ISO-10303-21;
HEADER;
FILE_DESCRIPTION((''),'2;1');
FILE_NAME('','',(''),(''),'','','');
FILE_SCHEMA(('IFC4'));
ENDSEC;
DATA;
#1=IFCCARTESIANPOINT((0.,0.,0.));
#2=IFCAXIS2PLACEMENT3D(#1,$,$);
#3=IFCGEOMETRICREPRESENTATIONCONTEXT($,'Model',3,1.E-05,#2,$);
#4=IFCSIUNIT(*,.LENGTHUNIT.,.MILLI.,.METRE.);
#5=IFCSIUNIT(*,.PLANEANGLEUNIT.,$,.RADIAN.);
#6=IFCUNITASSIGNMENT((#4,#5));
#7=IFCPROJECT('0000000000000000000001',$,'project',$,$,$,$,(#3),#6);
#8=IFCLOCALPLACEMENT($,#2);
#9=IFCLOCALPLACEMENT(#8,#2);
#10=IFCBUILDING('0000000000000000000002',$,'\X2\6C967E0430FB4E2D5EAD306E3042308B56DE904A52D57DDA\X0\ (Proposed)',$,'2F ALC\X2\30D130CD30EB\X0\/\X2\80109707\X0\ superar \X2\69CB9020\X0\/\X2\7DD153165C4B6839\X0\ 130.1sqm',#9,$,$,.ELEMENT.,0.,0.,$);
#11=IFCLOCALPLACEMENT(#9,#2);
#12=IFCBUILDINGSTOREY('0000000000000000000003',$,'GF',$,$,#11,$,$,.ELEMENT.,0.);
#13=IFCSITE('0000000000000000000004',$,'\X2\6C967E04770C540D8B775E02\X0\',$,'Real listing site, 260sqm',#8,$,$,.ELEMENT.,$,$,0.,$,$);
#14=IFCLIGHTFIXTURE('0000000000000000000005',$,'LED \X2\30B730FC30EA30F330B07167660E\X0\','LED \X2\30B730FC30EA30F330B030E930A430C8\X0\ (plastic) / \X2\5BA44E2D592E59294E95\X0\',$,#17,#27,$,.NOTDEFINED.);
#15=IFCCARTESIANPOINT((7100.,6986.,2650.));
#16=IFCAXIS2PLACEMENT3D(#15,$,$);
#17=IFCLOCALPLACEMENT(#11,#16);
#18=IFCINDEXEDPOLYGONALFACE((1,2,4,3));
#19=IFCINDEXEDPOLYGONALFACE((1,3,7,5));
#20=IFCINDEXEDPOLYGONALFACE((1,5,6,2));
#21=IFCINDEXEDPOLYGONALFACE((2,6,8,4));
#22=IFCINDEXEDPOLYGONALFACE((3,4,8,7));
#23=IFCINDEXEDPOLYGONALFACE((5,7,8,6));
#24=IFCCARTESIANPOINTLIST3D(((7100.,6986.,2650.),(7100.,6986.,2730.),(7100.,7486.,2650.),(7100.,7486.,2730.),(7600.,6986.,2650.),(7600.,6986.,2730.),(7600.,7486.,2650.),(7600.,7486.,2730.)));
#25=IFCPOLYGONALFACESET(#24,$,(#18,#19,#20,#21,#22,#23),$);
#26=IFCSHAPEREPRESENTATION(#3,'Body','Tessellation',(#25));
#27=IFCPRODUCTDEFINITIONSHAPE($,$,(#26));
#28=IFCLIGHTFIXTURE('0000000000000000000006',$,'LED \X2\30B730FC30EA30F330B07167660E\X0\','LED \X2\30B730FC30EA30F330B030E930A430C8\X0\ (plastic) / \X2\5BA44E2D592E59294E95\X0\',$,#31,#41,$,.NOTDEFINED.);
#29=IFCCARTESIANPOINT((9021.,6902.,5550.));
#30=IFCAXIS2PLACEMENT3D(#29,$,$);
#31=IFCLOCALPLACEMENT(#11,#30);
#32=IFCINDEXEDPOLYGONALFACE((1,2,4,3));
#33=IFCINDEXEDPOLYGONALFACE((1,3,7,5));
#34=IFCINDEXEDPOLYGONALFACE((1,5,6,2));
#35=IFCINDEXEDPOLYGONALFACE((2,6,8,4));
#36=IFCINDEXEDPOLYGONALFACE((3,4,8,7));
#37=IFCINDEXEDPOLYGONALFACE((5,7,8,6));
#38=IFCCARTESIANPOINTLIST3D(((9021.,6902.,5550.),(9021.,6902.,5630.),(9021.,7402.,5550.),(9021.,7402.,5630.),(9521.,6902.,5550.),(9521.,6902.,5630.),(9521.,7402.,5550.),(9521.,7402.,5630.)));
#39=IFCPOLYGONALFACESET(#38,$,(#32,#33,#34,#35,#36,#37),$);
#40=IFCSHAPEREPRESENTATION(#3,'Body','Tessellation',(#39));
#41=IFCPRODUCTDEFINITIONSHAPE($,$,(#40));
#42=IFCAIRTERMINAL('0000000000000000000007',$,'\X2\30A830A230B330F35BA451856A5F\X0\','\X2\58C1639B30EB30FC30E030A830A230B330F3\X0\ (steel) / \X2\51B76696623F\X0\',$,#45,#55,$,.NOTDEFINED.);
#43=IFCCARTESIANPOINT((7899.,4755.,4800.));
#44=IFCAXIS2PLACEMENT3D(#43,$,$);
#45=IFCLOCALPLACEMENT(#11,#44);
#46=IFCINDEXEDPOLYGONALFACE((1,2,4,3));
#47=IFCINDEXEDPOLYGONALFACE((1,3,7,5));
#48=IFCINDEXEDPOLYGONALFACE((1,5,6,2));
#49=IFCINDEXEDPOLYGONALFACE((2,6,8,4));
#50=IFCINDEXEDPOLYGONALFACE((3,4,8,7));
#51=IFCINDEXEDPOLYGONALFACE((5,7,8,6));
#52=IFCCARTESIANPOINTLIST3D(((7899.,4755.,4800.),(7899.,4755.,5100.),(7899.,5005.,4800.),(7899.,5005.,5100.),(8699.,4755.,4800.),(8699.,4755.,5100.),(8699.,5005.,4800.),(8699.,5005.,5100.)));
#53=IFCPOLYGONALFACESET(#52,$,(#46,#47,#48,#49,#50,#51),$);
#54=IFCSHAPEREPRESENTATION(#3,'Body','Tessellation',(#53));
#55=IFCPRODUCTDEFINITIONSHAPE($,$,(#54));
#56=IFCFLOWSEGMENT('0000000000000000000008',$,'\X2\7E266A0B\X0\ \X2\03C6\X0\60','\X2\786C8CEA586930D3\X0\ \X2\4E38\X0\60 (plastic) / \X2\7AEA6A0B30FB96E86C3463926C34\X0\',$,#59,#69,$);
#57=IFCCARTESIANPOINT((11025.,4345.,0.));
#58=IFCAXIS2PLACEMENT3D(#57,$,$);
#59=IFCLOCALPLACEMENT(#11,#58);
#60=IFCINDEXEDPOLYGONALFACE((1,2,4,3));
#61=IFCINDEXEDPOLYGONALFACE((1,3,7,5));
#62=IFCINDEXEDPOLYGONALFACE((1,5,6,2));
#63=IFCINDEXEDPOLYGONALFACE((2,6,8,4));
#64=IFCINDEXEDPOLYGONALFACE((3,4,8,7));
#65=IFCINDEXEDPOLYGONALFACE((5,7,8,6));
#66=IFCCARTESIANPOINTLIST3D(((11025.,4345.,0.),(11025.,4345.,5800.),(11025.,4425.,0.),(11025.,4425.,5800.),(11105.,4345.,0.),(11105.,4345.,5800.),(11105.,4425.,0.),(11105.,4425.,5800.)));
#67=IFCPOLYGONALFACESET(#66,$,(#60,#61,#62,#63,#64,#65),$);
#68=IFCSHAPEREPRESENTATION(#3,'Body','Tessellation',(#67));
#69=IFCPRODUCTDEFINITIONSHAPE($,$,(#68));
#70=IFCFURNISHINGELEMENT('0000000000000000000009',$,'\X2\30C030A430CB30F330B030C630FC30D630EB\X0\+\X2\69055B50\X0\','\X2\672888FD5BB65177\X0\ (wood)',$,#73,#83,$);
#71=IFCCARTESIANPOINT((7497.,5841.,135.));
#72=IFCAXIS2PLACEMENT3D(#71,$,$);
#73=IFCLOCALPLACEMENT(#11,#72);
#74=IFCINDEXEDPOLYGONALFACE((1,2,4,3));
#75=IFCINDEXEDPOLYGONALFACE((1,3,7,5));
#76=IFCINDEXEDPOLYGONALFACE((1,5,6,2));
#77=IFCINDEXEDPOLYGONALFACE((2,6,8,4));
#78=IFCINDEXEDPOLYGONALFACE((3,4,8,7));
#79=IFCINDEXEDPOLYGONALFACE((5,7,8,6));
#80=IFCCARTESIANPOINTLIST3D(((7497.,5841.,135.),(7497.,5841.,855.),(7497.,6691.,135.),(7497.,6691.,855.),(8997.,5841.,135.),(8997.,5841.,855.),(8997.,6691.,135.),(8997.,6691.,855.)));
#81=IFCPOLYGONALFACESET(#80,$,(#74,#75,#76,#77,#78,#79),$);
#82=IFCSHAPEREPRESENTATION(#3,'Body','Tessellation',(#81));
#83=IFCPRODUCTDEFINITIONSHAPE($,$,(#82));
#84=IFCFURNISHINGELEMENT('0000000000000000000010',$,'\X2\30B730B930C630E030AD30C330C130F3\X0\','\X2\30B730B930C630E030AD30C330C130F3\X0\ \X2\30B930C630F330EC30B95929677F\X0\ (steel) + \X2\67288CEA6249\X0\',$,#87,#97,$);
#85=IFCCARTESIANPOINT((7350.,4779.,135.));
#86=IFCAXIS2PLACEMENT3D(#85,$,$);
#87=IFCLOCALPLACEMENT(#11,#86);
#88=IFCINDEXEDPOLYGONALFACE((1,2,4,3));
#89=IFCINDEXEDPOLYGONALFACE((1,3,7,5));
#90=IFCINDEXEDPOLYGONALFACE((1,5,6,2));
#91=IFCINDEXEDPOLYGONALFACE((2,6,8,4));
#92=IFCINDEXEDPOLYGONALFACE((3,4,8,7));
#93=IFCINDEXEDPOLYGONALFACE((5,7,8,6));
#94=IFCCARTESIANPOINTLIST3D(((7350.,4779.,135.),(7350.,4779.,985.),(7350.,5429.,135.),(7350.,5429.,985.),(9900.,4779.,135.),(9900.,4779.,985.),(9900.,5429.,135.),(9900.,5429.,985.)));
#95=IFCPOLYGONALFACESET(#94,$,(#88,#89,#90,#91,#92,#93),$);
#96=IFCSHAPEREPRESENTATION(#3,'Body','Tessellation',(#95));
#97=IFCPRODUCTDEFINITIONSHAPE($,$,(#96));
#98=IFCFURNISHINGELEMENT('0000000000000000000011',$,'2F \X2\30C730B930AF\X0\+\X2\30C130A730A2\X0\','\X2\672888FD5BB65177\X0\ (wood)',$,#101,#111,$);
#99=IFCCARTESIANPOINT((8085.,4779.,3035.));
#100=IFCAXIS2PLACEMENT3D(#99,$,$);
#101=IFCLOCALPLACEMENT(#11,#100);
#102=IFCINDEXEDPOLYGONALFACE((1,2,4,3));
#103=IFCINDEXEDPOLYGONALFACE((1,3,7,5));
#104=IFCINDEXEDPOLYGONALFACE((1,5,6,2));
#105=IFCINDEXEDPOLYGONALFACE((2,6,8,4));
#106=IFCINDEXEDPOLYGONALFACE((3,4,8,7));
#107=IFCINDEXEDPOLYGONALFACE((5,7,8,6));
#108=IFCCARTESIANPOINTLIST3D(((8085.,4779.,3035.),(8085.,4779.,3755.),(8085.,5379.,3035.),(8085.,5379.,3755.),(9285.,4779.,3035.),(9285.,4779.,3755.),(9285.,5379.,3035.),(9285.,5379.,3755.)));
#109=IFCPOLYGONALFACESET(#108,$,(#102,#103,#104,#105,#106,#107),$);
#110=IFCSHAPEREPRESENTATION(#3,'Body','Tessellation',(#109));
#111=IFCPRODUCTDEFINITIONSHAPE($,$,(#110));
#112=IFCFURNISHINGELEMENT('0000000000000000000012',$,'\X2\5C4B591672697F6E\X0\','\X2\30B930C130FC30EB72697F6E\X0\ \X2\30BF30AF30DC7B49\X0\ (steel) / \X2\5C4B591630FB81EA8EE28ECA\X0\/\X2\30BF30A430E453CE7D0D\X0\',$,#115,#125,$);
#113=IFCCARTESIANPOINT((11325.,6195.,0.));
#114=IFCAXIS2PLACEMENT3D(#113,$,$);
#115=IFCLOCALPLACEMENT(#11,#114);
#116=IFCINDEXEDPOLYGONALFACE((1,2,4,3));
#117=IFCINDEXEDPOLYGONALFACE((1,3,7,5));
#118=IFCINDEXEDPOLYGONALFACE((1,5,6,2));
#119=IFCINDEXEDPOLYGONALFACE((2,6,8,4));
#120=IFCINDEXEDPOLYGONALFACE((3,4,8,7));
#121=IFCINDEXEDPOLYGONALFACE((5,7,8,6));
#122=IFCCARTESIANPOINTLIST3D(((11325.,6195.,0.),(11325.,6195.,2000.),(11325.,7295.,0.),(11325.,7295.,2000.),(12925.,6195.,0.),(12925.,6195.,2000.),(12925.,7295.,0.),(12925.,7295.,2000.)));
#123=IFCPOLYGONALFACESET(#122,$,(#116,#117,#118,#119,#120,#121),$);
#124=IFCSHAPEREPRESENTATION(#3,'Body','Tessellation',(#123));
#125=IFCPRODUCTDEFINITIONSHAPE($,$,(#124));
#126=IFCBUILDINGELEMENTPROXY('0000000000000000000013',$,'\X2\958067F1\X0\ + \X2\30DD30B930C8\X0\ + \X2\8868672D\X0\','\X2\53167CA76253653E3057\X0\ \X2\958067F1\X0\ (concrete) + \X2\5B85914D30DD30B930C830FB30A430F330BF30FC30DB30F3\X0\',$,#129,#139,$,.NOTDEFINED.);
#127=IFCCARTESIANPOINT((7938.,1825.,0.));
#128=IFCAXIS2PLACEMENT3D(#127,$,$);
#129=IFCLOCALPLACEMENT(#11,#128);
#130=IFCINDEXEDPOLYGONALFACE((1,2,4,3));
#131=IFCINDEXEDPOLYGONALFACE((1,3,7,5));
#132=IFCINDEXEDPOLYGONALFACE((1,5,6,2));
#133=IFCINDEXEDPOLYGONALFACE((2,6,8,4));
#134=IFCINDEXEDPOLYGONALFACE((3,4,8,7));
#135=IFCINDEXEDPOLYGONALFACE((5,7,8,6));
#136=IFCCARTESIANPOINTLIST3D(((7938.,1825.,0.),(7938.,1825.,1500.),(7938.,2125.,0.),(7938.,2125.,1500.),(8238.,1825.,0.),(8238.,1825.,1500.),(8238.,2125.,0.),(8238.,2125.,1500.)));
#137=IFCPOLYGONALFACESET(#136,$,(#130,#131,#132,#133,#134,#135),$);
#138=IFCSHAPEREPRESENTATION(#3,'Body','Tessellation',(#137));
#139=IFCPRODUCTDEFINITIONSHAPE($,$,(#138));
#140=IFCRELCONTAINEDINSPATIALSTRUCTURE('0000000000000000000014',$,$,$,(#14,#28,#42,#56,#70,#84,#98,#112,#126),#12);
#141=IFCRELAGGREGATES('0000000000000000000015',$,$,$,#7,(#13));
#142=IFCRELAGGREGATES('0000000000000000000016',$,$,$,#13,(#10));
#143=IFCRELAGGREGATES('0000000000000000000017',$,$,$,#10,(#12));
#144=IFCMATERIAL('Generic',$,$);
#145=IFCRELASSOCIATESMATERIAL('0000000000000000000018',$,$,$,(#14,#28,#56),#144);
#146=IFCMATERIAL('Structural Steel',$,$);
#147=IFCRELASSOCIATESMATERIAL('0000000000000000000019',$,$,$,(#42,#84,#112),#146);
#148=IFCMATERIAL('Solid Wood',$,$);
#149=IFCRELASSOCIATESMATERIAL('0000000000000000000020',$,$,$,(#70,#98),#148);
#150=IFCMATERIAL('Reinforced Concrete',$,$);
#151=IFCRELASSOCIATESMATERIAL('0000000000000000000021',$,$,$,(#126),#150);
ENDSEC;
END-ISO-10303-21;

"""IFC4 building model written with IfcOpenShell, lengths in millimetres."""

from ifc_helpers import new_model, si_unit, frame, frame_2d, origin, place, context, project, spatial, rectangle, extrude, material, element, save


model = new_model("IFC4")

# Units and contexts
model_context = context("Model", 3, precision=1e-05, world=origin())
ifc_project = project(units=[si_unit("LENGTHUNIT", "METRE", prefix="MILLI"), si_unit("PLANEANGLEUNIT", "RADIAN")], contexts=[model_context])

# Site, building, storey
site_placement = place(None, origin())
site = spatial("IfcSite", under=ifc_project, at=site_placement, Name="沖縄県名護市", ObjectType="Real listing site, 260sqm", CompositionType="ELEMENT", RefElevation=0.0)
building_placement = place(site_placement, origin())
building = spatial("IfcBuilding", under=site, at=building_placement, Name="沖縄・中庭のある回遊動線 (Proposed)", ObjectType="2F ALCパネル/耐震 superar 構造/緑化屋根 130.1sqm", CompositionType="ELEMENT", ElevationOfRefHeight=0.0, ElevationOfTerrain=0.0)
storey_placement = place(building_placement, origin())
storey = spatial("IfcBuildingStorey", under=building, at=storey_placement, Name="GF", CompositionType="ELEMENT", Elevation=0.0)

# Shared definitions
ifc_material_1 = material(Name="Solid Wood")

# Shared definitions
ifc_material_2 = material(Name="Reinforced Concrete")

# Shared definitions
ifc_material_3 = material(Name="Structural Steel")

# Shared definitions
ifc_material_4 = material(Name="Generic")

# Light fixtures
light_fixture_1_placement = place(storey_placement, frame((7100.0, 6986.0, 2650.0)))
element("IfcLightFixture", 1, at=light_fixture_1_placement, inside=storey, material=ifc_material_4, Name="LED シーリング照明", Description="LED シーリングライト (plastic) / 室中央天井", PredefinedType="NOTDEFINED", context=model_context, shape_type="SweptSolid", body=[
    extrude(rectangle(XDim=500.0, YDim=500.0, at=frame_2d((250.0, 250.0))), frame((7100.0, 6986.0, 2650.0)), (0.0, 0.0, 1.0), 80.0),
])
light_fixture_2_placement = place(storey_placement, frame((9021.0, 6902.0, 5550.0)))
element("IfcLightFixture", 2, at=light_fixture_2_placement, inside=storey, material=ifc_material_4, Name="LED シーリング照明", Description="LED シーリングライト (plastic) / 室中央天井", PredefinedType="NOTDEFINED", context=model_context, shape_type="SweptSolid", body=[
    extrude(rectangle(XDim=500.0, YDim=500.0, at=frame_2d((250.0, 250.0))), frame((9021.0, 6902.0, 5550.0)), (0.0, 0.0, 1.0), 80.0),
])

# Air terminal
air_terminal_placement = place(storey_placement, frame((7899.0, 4755.0, 4800.0)))
element("IfcAirTerminal", 3, at=air_terminal_placement, inside=storey, material=ifc_material_3, Name="エアコン室内機", Description="壁掛ルームエアコン (steel) / 冷暖房", PredefinedType="NOTDEFINED", context=model_context, shape_type="SweptSolid", body=[
    extrude(rectangle(XDim=800.0, YDim=250.0, at=frame_2d((400.0, 125.0))), frame((7899.0, 4755.0, 4800.0)), (0.0, 0.0, 1.0), 300.0),
])

# Flow segment
flow_segment_placement = place(storey_placement, frame((11025.0, 4345.0, 0.0)))
element("IfcFlowSegment", 4, at=flow_segment_placement, inside=storey, material=ifc_material_4, Name="縦樋 φ60", Description="硬質塩ビ 丸60 (plastic) / 竪樋・雨水排水", context=model_context, shape_type="SweptSolid", body=[
    extrude(rectangle(XDim=80.0, YDim=80.0, at=frame_2d((40.0, 40.0))), frame((11025.0, 4345.0, 0.0)), (0.0, 0.0, 1.0), 5800.0),
])

# Furnishing elements
furnishing_1_placement = place(storey_placement, frame((7497.0, 5841.0, 135.0)))
element("IfcFurnishingElement", 5, at=furnishing_1_placement, inside=storey, material=ifc_material_1, Name="ダイニングテーブル+椅子", Description="木製家具 (wood)", context=model_context, shape_type="SweptSolid", body=[
    extrude(rectangle(XDim=1500.0, YDim=850.0, at=frame_2d((750.0, 425.0))), frame((7497.0, 5841.0, 135.0)), (0.0, 0.0, 1.0), 720.0),
])
furnishing_2_placement = place(storey_placement, frame((7350.0, 4779.0, 135.0)))
element("IfcFurnishingElement", 6, at=furnishing_2_placement, inside=storey, material=ifc_material_3, Name="システムキッチン", Description="システムキッチン ステンレス天板 (steel) + 木質扉", context=model_context, shape_type="SweptSolid", body=[
    extrude(rectangle(XDim=2550.0, YDim=650.0, at=frame_2d((1275.0, 325.0))), frame((7350.0, 4779.0, 135.0)), (0.0, 0.0, 1.0), 850.0),
])
furnishing_3_placement = place(storey_placement, frame((8085.0, 4779.0, 3035.0)))
element("IfcFurnishingElement", 7, at=furnishing_3_placement, inside=storey, material=ifc_material_1, Name="2F デスク+チェア", Description="木製家具 (wood)", context=model_context, shape_type="SweptSolid", body=[
    extrude(rectangle(XDim=1200.0, YDim=600.0, at=frame_2d((600.0, 300.0))), frame((8085.0, 4779.0, 3035.0)), (0.0, 0.0, 1.0), 720.0),
])
furnishing_4_placement = place(storey_placement, frame((11325.0, 6195.0, 0.0)))
element("IfcFurnishingElement", 8, at=furnishing_4_placement, inside=storey, material=ifc_material_3, Name="屋外物置", Description="スチール物置 タクボ等 (steel) / 屋外・自転車/タイヤ収納", context=model_context, shape_type="SweptSolid", body=[
    extrude(rectangle(XDim=1600.0, YDim=1100.0, at=frame_2d((800.0, 550.0))), frame((11325.0, 6195.0, 0.0)), (0.0, 0.0, 1.0), 2000.0),
])

# Building element proxy
proxy_placement = place(storey_placement, frame((7938.0, 1825.0, 0.0)))
element("IfcBuildingElementProxy", 9, at=proxy_placement, inside=storey, material=ifc_material_2, Name="門柱 + ポスト + 表札", Description="化粧打放し 門柱 (concrete) + 宅配ポスト・インターホン", PredefinedType="NOTDEFINED", context=model_context, shape_type="SweptSolid", body=[
    extrude(rectangle(XDim=300.0, YDim=300.0, at=frame_2d((150.0, 150.0))), frame((7938.0, 1825.0, 0.0)), (0.0, 0.0, 1.0), 1500.0),
])

save(model, "model.ifc")
